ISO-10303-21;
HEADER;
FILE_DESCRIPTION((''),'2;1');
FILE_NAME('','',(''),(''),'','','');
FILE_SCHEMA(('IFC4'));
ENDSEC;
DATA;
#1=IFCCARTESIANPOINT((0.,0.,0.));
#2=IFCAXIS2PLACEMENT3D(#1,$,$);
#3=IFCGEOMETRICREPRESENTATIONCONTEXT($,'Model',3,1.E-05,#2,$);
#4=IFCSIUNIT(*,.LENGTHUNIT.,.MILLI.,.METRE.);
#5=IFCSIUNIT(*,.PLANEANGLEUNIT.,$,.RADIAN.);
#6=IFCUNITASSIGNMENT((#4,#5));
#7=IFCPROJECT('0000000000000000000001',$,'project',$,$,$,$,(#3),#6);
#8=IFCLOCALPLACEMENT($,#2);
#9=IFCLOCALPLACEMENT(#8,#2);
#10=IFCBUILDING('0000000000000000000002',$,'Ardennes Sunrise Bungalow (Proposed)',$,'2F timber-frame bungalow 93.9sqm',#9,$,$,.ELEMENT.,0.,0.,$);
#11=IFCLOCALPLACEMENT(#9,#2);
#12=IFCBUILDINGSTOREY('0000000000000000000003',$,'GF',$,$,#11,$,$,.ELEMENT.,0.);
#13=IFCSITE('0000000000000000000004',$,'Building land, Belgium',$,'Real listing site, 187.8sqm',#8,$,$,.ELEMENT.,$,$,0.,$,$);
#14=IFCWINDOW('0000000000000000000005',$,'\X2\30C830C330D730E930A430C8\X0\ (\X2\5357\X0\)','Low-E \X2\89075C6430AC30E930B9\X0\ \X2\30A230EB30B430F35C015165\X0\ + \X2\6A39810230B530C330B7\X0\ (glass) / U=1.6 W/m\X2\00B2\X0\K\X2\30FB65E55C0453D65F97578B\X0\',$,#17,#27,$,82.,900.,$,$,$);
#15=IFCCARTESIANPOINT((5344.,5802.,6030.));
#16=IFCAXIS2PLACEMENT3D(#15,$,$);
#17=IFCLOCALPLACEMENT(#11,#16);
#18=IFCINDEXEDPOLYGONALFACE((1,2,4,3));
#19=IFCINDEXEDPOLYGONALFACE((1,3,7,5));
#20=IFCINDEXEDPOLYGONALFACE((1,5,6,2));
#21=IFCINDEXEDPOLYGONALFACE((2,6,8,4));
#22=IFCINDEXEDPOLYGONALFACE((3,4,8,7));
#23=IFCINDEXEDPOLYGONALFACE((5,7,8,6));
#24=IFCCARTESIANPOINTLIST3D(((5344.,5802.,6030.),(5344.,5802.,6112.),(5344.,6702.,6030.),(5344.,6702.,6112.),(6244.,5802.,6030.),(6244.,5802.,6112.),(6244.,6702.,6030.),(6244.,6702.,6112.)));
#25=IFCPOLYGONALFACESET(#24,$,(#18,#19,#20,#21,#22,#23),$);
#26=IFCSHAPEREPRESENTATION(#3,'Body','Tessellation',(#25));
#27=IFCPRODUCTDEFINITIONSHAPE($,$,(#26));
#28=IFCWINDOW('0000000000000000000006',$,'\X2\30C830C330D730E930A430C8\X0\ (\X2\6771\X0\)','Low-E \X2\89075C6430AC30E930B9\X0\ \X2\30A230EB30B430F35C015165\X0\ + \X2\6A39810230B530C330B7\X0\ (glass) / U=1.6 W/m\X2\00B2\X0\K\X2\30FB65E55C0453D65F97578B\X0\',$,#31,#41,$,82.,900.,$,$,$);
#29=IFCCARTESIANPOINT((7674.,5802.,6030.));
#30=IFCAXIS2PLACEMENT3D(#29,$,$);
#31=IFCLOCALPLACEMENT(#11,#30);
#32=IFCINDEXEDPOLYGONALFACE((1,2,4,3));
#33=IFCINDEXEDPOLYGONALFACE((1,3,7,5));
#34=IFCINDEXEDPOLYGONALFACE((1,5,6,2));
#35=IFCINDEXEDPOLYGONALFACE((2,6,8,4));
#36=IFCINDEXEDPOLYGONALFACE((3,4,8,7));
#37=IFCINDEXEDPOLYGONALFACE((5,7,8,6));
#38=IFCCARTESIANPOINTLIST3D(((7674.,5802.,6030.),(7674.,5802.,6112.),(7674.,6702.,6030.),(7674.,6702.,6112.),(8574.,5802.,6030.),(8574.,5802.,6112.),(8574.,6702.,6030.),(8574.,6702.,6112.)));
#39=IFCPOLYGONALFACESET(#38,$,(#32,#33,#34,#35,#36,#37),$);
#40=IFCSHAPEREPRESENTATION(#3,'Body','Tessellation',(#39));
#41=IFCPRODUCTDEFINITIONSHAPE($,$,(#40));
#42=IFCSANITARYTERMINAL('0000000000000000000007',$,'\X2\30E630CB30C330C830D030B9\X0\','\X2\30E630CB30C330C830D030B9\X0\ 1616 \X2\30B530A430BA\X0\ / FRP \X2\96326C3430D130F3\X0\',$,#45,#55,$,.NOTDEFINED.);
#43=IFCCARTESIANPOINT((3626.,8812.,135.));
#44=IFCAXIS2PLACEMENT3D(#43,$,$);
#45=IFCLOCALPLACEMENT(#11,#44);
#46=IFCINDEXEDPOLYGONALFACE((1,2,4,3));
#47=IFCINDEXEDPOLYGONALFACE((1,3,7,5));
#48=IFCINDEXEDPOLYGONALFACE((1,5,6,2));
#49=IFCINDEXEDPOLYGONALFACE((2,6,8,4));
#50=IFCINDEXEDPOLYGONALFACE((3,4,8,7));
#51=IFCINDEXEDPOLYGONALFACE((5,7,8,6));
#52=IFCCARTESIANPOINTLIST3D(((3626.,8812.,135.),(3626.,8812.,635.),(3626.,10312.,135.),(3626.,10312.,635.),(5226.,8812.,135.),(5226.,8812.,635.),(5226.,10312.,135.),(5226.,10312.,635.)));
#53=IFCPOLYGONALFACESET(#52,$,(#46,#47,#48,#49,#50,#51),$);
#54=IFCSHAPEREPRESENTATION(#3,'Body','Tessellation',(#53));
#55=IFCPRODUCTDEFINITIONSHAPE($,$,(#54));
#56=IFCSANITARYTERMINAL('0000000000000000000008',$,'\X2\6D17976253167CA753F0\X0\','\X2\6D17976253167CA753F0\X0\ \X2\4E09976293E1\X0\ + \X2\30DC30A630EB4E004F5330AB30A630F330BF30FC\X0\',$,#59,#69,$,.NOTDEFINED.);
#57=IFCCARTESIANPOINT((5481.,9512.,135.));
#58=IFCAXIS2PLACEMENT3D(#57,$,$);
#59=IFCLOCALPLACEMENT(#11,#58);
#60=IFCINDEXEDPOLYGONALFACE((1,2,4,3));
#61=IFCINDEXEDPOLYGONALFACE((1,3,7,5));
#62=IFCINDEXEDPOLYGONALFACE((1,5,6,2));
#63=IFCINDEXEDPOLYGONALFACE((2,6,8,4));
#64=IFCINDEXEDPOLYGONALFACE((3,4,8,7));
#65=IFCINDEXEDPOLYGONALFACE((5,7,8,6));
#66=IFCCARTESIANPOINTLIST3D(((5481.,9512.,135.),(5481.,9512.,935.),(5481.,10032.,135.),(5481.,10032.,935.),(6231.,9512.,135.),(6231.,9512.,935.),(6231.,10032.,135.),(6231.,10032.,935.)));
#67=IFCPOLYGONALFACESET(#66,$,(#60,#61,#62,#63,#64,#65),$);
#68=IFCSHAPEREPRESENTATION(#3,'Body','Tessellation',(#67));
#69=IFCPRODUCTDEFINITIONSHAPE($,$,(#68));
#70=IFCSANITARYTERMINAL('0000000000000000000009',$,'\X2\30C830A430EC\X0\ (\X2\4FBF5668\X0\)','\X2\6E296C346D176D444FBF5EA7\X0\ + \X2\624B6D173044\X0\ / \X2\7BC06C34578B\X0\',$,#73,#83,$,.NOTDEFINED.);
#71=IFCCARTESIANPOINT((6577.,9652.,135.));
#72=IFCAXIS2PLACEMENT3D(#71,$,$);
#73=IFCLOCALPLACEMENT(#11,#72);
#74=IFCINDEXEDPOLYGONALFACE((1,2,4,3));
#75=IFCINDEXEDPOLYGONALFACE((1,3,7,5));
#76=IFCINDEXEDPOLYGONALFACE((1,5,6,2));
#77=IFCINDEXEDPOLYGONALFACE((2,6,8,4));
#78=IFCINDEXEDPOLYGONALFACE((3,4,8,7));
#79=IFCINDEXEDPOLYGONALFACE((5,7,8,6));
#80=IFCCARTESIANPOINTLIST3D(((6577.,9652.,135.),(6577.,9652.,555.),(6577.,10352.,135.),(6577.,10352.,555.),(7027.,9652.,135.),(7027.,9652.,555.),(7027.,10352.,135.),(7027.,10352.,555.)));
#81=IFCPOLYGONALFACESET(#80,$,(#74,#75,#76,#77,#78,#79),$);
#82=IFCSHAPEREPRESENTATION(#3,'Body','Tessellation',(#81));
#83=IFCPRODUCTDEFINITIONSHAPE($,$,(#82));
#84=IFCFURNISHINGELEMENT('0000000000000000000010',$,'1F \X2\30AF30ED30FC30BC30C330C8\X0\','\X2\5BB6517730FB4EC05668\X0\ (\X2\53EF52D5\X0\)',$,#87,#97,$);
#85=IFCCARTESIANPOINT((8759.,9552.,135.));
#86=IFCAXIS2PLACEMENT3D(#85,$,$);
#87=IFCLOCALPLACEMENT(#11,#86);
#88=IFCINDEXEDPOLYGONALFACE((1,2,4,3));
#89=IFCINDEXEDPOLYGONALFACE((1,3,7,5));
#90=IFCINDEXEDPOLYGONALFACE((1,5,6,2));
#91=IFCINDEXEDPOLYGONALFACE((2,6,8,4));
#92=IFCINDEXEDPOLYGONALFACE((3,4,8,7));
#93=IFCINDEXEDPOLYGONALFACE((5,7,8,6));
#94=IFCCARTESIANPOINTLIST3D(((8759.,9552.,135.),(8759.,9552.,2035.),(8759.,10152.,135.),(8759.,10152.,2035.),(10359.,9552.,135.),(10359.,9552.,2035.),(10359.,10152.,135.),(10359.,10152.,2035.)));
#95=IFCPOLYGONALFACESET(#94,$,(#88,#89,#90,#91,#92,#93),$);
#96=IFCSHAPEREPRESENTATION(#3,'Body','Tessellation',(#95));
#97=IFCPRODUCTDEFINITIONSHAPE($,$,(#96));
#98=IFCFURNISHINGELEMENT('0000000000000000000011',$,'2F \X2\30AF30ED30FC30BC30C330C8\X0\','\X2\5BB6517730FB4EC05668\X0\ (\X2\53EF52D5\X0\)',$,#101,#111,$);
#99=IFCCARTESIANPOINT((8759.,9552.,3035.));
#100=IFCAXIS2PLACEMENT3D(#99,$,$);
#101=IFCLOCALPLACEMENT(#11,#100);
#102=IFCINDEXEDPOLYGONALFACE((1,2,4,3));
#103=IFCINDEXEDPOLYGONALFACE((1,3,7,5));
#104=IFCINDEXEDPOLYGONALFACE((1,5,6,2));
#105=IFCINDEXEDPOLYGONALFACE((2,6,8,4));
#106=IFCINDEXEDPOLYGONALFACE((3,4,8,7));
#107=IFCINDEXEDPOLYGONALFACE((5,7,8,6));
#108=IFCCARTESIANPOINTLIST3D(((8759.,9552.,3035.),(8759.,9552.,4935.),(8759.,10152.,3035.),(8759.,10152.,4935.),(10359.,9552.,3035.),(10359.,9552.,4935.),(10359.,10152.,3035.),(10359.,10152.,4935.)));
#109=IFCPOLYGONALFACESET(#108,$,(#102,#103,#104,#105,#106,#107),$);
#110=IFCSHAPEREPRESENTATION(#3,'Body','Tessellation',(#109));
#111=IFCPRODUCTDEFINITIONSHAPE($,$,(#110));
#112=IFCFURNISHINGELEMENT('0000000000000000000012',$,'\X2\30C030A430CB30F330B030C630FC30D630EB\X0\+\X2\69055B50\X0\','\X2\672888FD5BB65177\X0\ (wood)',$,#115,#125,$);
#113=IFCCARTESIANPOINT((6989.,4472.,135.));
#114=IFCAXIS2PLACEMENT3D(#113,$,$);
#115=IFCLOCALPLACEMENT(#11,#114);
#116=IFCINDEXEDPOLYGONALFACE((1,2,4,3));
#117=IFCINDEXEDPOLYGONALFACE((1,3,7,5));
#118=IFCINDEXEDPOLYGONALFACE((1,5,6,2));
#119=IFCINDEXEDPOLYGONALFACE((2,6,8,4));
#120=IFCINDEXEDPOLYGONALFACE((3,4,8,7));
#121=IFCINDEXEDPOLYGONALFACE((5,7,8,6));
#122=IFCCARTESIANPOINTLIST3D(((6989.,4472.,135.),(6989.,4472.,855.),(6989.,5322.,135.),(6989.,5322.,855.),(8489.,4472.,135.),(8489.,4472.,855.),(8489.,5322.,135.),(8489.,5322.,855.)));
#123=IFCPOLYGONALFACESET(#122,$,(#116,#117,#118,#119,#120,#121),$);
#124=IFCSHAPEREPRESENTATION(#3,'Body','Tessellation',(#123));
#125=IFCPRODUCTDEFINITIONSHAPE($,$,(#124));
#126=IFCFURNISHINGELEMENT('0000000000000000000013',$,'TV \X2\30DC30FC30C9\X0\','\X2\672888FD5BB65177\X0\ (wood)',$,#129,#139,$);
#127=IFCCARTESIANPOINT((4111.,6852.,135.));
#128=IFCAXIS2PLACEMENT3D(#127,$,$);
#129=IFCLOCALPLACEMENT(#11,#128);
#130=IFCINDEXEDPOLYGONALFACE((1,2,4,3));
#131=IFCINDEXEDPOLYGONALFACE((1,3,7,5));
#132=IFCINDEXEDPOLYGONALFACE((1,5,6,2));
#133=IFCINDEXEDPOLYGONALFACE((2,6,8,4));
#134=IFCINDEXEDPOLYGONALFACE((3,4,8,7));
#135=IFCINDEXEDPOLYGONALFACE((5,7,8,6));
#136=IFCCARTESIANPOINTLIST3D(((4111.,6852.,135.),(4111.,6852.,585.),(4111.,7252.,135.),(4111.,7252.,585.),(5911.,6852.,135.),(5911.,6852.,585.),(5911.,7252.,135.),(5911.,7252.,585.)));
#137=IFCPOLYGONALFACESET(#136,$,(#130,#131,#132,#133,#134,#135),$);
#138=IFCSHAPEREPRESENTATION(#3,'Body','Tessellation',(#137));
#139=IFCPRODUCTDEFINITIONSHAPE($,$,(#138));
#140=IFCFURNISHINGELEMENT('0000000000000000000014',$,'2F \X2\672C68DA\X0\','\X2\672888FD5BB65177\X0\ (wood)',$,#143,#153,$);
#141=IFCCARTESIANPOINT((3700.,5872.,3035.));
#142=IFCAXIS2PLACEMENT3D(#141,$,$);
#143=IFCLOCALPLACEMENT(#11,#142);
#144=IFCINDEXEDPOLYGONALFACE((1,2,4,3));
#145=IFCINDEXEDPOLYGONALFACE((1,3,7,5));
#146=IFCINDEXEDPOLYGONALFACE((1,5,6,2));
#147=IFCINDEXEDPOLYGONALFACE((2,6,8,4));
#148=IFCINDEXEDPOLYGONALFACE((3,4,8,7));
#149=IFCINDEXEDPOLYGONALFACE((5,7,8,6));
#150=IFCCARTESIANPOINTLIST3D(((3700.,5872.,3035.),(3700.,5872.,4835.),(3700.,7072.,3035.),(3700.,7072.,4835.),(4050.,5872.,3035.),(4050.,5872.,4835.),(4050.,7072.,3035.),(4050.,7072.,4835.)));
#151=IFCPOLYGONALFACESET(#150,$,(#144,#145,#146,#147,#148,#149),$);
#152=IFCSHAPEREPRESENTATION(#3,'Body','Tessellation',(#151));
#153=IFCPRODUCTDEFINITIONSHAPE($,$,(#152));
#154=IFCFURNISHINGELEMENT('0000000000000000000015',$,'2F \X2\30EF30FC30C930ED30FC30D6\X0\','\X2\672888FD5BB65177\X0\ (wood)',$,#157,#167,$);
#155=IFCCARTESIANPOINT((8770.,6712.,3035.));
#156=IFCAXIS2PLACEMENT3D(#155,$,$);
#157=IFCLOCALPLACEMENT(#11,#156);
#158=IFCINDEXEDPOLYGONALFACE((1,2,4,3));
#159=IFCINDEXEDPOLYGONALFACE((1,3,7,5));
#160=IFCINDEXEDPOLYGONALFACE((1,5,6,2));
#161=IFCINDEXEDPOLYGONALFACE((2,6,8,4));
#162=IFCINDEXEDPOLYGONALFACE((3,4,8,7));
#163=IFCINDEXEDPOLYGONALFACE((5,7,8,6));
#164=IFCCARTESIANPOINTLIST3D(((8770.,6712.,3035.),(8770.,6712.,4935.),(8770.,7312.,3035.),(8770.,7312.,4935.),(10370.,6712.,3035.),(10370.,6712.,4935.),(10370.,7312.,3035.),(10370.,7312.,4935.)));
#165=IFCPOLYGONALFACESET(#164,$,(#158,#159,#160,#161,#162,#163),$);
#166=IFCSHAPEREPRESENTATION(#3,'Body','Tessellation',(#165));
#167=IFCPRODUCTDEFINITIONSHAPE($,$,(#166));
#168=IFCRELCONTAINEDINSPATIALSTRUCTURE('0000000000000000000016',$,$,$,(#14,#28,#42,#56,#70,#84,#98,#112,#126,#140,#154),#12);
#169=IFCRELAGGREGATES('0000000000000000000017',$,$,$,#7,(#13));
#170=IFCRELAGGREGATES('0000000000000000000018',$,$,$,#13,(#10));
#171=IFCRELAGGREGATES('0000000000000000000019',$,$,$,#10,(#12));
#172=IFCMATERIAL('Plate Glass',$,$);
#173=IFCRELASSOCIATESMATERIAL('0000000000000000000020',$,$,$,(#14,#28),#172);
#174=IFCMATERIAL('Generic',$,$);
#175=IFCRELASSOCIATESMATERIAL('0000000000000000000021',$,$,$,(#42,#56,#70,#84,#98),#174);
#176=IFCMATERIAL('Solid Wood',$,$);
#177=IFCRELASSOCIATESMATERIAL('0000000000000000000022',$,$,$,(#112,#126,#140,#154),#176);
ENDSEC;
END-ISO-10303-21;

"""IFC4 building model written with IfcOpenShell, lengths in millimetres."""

from ifc_helpers import new_model, si_unit, frame, frame_2d, origin, place, context, project, spatial, rectangle, extrude, material, element, save


model = new_model("IFC4")

# Units and contexts
model_context = context("Model", 3, precision=1e-05, world=origin())
ifc_project = project(units=[si_unit("LENGTHUNIT", "METRE", prefix="MILLI"), si_unit("PLANEANGLEUNIT", "RADIAN")], contexts=[model_context])

# Site, building, storey
site_placement = place(None, origin())
site = spatial("IfcSite", under=ifc_project, at=site_placement, Name="Building land, Belgium", ObjectType="Real listing site, 187.8sqm", CompositionType="ELEMENT", RefElevation=0.0)
building_placement = place(site_placement, origin())
building = spatial("IfcBuilding", under=site, at=building_placement, Name="Ardennes Sunrise Bungalow (Proposed)", ObjectType="2F timber-frame bungalow 93.9sqm", CompositionType="ELEMENT", ElevationOfRefHeight=0.0, ElevationOfTerrain=0.0)
storey_placement = place(building_placement, origin())
storey = spatial("IfcBuildingStorey", under=building, at=storey_placement, Name="GF", CompositionType="ELEMENT", Elevation=0.0)

# Shared definitions
ifc_material_1 = material(Name="Solid Wood")
ifc_material_2 = material(Name="Plate Glass")

# Windows
window_1_placement = place(storey_placement, frame((5344.0, 5802.0, 6030.0)))
element("IfcWindow", 1, at=window_1_placement, inside=storey, material=ifc_material_2, Name="トップライト (南)", Description="Low-E 複層ガラス アルゴン封入 + 樹脂サッシ (glass) / U=1.6 W/m²K・日射取得型", OverallHeight=82.0, OverallWidth=900.0, context=model_context, shape_type="SweptSolid", body=[
    extrude(rectangle(XDim=900.0, YDim=900.0, at=frame_2d((450.0, 450.0))), frame((5344.0, 5802.0, 6030.0)), (0.0, 0.0, 1.0), 82.0),
])
window_2_placement = place(storey_placement, frame((7674.0, 5802.0, 6030.0)))
element("IfcWindow", 2, at=window_2_placement, inside=storey, material=ifc_material_2, Name="トップライト (東)", Description="Low-E 複層ガラス アルゴン封入 + 樹脂サッシ (glass) / U=1.6 W/m²K・日射取得型", OverallHeight=82.0, OverallWidth=900.0, context=model_context, shape_type="SweptSolid", body=[
    extrude(rectangle(XDim=900.0, YDim=900.0, at=frame_2d((450.0, 450.0))), frame((7674.0, 5802.0, 6030.0)), (0.0, 0.0, 1.0), 82.0),
])

# Sanitary terminals
ifc_material_3 = material(Name="Generic")
sanitary_terminal_1_placement = place(storey_placement, frame((3626.0, 8812.0, 135.0)))
element("IfcSanitaryTerminal", 3, at=sanitary_terminal_1_placement, inside=storey, material=ifc_material_3, Name="ユニットバス", Description="ユニットバス 1616 サイズ / FRP 防水パン", PredefinedType="NOTDEFINED", context=model_context, shape_type="SweptSolid", body=[
    extrude(rectangle(XDim=1600.0, YDim=1500.0, at=frame_2d((800.0, 750.0))), frame((3626.0, 8812.0, 135.0)), (0.0, 0.0, 1.0), 500.0),
])
sanitary_terminal_2_placement = place(storey_placement, frame((5481.0, 9512.0, 135.0)))
element("IfcSanitaryTerminal", 4, at=sanitary_terminal_2_placement, inside=storey, material=ifc_material_3, Name="洗面化粧台", Description="洗面化粧台 三面鏡 + ボウル一体カウンター", PredefinedType="NOTDEFINED", context=model_context, shape_type="SweptSolid", body=[
    extrude(rectangle(XDim=750.0, YDim=520.0, at=frame_2d((375.0, 260.0))), frame((5481.0, 9512.0, 135.0)), (0.0, 0.0, 1.0), 800.0),
])
sanitary_terminal_3_placement = place(storey_placement, frame((6577.0, 9652.0, 135.0)))
element("IfcSanitaryTerminal", 5, at=sanitary_terminal_3_placement, inside=storey, material=ifc_material_3, Name="トイレ (便器)", Description="温水洗浄便座 + 手洗い / 節水型", PredefinedType="NOTDEFINED", context=model_context, shape_type="SweptSolid", body=[
    extrude(rectangle(XDim=450.0, YDim=700.0, at=frame_2d((225.0, 350.0))), frame((6577.0, 9652.0, 135.0)), (0.0, 0.0, 1.0), 420.0),
])

# Furnishing elements
furnishing_1_placement = place(storey_placement, frame((8759.0, 9552.0, 135.0)))
element("IfcFurnishingElement", 6, at=furnishing_1_placement, inside=storey, material=ifc_material_3, Name="1F クローゼット", Description="家具・什器 (可動)", context=model_context, shape_type="SweptSolid", body=[
    extrude(rectangle(XDim=1600.0, YDim=600.0, at=frame_2d((800.0, 300.0))), frame((8759.0, 9552.0, 135.0)), (0.0, 0.0, 1.0), 1900.0),
])
furnishing_2_placement = place(storey_placement, frame((8759.0, 9552.0, 3035.0)))
element("IfcFurnishingElement", 7, at=furnishing_2_placement, inside=storey, material=ifc_material_3, Name="2F クローゼット", Description="家具・什器 (可動)", context=model_context, shape_type="SweptSolid", body=[
    extrude(rectangle(XDim=1600.0, YDim=600.0, at=frame_2d((800.0, 300.0))), frame((8759.0, 9552.0, 3035.0)), (0.0, 0.0, 1.0), 1900.0),
])
furnishing_3_placement = place(storey_placement, frame((6989.0, 4472.0, 135.0)))
element("IfcFurnishingElement", 8, at=furnishing_3_placement, inside=storey, material=ifc_material_1, Name="ダイニングテーブル+椅子", Description="木製家具 (wood)", context=model_context, shape_type="SweptSolid", body=[
    extrude(rectangle(XDim=1500.0, YDim=850.0, at=frame_2d((750.0, 425.0))), frame((6989.0, 4472.0, 135.0)), (0.0, 0.0, 1.0), 720.0),
])
furnishing_4_placement = place(storey_placement, frame((4111.0, 6852.0, 135.0)))
element("IfcFurnishingElement", 9, at=furnishing_4_placement, inside=storey, material=ifc_material_1, Name="TV ボード", Description="木製家具 (wood)", context=model_context, shape_type="SweptSolid", body=[
    extrude(rectangle(XDim=1800.0, YDim=400.0, at=frame_2d((900.0, 200.0))), frame((4111.0, 6852.0, 135.0)), (0.0, 0.0, 1.0), 450.0),
])
furnishing_5_placement = place(storey_placement, frame((3700.0, 5872.0, 3035.0)))
element("IfcFurnishingElement", 10, at=furnishing_5_placement, inside=storey, material=ifc_material_1, Name="2F 本棚", Description="木製家具 (wood)", context=model_context, shape_type="SweptSolid", body=[
    extrude(rectangle(XDim=350.0, YDim=1200.0, at=frame_2d((175.0, 600.0))), frame((3700.0, 5872.0, 3035.0)), (0.0, 0.0, 1.0), 1800.0),
])
furnishing_6_placement = place(storey_placement, frame((8770.0, 6712.0, 3035.0)))
element("IfcFurnishingElement", 11, at=furnishing_6_placement, inside=storey, material=ifc_material_1, Name="2F ワードローブ", Description="木製家具 (wood)", context=model_context, shape_type="SweptSolid", body=[
    extrude(rectangle(XDim=1600.0, YDim=600.0, at=frame_2d((800.0, 300.0))), frame((8770.0, 6712.0, 3035.0)), (0.0, 0.0, 1.0), 1900.0),
])

save(model, "model.ifc")
